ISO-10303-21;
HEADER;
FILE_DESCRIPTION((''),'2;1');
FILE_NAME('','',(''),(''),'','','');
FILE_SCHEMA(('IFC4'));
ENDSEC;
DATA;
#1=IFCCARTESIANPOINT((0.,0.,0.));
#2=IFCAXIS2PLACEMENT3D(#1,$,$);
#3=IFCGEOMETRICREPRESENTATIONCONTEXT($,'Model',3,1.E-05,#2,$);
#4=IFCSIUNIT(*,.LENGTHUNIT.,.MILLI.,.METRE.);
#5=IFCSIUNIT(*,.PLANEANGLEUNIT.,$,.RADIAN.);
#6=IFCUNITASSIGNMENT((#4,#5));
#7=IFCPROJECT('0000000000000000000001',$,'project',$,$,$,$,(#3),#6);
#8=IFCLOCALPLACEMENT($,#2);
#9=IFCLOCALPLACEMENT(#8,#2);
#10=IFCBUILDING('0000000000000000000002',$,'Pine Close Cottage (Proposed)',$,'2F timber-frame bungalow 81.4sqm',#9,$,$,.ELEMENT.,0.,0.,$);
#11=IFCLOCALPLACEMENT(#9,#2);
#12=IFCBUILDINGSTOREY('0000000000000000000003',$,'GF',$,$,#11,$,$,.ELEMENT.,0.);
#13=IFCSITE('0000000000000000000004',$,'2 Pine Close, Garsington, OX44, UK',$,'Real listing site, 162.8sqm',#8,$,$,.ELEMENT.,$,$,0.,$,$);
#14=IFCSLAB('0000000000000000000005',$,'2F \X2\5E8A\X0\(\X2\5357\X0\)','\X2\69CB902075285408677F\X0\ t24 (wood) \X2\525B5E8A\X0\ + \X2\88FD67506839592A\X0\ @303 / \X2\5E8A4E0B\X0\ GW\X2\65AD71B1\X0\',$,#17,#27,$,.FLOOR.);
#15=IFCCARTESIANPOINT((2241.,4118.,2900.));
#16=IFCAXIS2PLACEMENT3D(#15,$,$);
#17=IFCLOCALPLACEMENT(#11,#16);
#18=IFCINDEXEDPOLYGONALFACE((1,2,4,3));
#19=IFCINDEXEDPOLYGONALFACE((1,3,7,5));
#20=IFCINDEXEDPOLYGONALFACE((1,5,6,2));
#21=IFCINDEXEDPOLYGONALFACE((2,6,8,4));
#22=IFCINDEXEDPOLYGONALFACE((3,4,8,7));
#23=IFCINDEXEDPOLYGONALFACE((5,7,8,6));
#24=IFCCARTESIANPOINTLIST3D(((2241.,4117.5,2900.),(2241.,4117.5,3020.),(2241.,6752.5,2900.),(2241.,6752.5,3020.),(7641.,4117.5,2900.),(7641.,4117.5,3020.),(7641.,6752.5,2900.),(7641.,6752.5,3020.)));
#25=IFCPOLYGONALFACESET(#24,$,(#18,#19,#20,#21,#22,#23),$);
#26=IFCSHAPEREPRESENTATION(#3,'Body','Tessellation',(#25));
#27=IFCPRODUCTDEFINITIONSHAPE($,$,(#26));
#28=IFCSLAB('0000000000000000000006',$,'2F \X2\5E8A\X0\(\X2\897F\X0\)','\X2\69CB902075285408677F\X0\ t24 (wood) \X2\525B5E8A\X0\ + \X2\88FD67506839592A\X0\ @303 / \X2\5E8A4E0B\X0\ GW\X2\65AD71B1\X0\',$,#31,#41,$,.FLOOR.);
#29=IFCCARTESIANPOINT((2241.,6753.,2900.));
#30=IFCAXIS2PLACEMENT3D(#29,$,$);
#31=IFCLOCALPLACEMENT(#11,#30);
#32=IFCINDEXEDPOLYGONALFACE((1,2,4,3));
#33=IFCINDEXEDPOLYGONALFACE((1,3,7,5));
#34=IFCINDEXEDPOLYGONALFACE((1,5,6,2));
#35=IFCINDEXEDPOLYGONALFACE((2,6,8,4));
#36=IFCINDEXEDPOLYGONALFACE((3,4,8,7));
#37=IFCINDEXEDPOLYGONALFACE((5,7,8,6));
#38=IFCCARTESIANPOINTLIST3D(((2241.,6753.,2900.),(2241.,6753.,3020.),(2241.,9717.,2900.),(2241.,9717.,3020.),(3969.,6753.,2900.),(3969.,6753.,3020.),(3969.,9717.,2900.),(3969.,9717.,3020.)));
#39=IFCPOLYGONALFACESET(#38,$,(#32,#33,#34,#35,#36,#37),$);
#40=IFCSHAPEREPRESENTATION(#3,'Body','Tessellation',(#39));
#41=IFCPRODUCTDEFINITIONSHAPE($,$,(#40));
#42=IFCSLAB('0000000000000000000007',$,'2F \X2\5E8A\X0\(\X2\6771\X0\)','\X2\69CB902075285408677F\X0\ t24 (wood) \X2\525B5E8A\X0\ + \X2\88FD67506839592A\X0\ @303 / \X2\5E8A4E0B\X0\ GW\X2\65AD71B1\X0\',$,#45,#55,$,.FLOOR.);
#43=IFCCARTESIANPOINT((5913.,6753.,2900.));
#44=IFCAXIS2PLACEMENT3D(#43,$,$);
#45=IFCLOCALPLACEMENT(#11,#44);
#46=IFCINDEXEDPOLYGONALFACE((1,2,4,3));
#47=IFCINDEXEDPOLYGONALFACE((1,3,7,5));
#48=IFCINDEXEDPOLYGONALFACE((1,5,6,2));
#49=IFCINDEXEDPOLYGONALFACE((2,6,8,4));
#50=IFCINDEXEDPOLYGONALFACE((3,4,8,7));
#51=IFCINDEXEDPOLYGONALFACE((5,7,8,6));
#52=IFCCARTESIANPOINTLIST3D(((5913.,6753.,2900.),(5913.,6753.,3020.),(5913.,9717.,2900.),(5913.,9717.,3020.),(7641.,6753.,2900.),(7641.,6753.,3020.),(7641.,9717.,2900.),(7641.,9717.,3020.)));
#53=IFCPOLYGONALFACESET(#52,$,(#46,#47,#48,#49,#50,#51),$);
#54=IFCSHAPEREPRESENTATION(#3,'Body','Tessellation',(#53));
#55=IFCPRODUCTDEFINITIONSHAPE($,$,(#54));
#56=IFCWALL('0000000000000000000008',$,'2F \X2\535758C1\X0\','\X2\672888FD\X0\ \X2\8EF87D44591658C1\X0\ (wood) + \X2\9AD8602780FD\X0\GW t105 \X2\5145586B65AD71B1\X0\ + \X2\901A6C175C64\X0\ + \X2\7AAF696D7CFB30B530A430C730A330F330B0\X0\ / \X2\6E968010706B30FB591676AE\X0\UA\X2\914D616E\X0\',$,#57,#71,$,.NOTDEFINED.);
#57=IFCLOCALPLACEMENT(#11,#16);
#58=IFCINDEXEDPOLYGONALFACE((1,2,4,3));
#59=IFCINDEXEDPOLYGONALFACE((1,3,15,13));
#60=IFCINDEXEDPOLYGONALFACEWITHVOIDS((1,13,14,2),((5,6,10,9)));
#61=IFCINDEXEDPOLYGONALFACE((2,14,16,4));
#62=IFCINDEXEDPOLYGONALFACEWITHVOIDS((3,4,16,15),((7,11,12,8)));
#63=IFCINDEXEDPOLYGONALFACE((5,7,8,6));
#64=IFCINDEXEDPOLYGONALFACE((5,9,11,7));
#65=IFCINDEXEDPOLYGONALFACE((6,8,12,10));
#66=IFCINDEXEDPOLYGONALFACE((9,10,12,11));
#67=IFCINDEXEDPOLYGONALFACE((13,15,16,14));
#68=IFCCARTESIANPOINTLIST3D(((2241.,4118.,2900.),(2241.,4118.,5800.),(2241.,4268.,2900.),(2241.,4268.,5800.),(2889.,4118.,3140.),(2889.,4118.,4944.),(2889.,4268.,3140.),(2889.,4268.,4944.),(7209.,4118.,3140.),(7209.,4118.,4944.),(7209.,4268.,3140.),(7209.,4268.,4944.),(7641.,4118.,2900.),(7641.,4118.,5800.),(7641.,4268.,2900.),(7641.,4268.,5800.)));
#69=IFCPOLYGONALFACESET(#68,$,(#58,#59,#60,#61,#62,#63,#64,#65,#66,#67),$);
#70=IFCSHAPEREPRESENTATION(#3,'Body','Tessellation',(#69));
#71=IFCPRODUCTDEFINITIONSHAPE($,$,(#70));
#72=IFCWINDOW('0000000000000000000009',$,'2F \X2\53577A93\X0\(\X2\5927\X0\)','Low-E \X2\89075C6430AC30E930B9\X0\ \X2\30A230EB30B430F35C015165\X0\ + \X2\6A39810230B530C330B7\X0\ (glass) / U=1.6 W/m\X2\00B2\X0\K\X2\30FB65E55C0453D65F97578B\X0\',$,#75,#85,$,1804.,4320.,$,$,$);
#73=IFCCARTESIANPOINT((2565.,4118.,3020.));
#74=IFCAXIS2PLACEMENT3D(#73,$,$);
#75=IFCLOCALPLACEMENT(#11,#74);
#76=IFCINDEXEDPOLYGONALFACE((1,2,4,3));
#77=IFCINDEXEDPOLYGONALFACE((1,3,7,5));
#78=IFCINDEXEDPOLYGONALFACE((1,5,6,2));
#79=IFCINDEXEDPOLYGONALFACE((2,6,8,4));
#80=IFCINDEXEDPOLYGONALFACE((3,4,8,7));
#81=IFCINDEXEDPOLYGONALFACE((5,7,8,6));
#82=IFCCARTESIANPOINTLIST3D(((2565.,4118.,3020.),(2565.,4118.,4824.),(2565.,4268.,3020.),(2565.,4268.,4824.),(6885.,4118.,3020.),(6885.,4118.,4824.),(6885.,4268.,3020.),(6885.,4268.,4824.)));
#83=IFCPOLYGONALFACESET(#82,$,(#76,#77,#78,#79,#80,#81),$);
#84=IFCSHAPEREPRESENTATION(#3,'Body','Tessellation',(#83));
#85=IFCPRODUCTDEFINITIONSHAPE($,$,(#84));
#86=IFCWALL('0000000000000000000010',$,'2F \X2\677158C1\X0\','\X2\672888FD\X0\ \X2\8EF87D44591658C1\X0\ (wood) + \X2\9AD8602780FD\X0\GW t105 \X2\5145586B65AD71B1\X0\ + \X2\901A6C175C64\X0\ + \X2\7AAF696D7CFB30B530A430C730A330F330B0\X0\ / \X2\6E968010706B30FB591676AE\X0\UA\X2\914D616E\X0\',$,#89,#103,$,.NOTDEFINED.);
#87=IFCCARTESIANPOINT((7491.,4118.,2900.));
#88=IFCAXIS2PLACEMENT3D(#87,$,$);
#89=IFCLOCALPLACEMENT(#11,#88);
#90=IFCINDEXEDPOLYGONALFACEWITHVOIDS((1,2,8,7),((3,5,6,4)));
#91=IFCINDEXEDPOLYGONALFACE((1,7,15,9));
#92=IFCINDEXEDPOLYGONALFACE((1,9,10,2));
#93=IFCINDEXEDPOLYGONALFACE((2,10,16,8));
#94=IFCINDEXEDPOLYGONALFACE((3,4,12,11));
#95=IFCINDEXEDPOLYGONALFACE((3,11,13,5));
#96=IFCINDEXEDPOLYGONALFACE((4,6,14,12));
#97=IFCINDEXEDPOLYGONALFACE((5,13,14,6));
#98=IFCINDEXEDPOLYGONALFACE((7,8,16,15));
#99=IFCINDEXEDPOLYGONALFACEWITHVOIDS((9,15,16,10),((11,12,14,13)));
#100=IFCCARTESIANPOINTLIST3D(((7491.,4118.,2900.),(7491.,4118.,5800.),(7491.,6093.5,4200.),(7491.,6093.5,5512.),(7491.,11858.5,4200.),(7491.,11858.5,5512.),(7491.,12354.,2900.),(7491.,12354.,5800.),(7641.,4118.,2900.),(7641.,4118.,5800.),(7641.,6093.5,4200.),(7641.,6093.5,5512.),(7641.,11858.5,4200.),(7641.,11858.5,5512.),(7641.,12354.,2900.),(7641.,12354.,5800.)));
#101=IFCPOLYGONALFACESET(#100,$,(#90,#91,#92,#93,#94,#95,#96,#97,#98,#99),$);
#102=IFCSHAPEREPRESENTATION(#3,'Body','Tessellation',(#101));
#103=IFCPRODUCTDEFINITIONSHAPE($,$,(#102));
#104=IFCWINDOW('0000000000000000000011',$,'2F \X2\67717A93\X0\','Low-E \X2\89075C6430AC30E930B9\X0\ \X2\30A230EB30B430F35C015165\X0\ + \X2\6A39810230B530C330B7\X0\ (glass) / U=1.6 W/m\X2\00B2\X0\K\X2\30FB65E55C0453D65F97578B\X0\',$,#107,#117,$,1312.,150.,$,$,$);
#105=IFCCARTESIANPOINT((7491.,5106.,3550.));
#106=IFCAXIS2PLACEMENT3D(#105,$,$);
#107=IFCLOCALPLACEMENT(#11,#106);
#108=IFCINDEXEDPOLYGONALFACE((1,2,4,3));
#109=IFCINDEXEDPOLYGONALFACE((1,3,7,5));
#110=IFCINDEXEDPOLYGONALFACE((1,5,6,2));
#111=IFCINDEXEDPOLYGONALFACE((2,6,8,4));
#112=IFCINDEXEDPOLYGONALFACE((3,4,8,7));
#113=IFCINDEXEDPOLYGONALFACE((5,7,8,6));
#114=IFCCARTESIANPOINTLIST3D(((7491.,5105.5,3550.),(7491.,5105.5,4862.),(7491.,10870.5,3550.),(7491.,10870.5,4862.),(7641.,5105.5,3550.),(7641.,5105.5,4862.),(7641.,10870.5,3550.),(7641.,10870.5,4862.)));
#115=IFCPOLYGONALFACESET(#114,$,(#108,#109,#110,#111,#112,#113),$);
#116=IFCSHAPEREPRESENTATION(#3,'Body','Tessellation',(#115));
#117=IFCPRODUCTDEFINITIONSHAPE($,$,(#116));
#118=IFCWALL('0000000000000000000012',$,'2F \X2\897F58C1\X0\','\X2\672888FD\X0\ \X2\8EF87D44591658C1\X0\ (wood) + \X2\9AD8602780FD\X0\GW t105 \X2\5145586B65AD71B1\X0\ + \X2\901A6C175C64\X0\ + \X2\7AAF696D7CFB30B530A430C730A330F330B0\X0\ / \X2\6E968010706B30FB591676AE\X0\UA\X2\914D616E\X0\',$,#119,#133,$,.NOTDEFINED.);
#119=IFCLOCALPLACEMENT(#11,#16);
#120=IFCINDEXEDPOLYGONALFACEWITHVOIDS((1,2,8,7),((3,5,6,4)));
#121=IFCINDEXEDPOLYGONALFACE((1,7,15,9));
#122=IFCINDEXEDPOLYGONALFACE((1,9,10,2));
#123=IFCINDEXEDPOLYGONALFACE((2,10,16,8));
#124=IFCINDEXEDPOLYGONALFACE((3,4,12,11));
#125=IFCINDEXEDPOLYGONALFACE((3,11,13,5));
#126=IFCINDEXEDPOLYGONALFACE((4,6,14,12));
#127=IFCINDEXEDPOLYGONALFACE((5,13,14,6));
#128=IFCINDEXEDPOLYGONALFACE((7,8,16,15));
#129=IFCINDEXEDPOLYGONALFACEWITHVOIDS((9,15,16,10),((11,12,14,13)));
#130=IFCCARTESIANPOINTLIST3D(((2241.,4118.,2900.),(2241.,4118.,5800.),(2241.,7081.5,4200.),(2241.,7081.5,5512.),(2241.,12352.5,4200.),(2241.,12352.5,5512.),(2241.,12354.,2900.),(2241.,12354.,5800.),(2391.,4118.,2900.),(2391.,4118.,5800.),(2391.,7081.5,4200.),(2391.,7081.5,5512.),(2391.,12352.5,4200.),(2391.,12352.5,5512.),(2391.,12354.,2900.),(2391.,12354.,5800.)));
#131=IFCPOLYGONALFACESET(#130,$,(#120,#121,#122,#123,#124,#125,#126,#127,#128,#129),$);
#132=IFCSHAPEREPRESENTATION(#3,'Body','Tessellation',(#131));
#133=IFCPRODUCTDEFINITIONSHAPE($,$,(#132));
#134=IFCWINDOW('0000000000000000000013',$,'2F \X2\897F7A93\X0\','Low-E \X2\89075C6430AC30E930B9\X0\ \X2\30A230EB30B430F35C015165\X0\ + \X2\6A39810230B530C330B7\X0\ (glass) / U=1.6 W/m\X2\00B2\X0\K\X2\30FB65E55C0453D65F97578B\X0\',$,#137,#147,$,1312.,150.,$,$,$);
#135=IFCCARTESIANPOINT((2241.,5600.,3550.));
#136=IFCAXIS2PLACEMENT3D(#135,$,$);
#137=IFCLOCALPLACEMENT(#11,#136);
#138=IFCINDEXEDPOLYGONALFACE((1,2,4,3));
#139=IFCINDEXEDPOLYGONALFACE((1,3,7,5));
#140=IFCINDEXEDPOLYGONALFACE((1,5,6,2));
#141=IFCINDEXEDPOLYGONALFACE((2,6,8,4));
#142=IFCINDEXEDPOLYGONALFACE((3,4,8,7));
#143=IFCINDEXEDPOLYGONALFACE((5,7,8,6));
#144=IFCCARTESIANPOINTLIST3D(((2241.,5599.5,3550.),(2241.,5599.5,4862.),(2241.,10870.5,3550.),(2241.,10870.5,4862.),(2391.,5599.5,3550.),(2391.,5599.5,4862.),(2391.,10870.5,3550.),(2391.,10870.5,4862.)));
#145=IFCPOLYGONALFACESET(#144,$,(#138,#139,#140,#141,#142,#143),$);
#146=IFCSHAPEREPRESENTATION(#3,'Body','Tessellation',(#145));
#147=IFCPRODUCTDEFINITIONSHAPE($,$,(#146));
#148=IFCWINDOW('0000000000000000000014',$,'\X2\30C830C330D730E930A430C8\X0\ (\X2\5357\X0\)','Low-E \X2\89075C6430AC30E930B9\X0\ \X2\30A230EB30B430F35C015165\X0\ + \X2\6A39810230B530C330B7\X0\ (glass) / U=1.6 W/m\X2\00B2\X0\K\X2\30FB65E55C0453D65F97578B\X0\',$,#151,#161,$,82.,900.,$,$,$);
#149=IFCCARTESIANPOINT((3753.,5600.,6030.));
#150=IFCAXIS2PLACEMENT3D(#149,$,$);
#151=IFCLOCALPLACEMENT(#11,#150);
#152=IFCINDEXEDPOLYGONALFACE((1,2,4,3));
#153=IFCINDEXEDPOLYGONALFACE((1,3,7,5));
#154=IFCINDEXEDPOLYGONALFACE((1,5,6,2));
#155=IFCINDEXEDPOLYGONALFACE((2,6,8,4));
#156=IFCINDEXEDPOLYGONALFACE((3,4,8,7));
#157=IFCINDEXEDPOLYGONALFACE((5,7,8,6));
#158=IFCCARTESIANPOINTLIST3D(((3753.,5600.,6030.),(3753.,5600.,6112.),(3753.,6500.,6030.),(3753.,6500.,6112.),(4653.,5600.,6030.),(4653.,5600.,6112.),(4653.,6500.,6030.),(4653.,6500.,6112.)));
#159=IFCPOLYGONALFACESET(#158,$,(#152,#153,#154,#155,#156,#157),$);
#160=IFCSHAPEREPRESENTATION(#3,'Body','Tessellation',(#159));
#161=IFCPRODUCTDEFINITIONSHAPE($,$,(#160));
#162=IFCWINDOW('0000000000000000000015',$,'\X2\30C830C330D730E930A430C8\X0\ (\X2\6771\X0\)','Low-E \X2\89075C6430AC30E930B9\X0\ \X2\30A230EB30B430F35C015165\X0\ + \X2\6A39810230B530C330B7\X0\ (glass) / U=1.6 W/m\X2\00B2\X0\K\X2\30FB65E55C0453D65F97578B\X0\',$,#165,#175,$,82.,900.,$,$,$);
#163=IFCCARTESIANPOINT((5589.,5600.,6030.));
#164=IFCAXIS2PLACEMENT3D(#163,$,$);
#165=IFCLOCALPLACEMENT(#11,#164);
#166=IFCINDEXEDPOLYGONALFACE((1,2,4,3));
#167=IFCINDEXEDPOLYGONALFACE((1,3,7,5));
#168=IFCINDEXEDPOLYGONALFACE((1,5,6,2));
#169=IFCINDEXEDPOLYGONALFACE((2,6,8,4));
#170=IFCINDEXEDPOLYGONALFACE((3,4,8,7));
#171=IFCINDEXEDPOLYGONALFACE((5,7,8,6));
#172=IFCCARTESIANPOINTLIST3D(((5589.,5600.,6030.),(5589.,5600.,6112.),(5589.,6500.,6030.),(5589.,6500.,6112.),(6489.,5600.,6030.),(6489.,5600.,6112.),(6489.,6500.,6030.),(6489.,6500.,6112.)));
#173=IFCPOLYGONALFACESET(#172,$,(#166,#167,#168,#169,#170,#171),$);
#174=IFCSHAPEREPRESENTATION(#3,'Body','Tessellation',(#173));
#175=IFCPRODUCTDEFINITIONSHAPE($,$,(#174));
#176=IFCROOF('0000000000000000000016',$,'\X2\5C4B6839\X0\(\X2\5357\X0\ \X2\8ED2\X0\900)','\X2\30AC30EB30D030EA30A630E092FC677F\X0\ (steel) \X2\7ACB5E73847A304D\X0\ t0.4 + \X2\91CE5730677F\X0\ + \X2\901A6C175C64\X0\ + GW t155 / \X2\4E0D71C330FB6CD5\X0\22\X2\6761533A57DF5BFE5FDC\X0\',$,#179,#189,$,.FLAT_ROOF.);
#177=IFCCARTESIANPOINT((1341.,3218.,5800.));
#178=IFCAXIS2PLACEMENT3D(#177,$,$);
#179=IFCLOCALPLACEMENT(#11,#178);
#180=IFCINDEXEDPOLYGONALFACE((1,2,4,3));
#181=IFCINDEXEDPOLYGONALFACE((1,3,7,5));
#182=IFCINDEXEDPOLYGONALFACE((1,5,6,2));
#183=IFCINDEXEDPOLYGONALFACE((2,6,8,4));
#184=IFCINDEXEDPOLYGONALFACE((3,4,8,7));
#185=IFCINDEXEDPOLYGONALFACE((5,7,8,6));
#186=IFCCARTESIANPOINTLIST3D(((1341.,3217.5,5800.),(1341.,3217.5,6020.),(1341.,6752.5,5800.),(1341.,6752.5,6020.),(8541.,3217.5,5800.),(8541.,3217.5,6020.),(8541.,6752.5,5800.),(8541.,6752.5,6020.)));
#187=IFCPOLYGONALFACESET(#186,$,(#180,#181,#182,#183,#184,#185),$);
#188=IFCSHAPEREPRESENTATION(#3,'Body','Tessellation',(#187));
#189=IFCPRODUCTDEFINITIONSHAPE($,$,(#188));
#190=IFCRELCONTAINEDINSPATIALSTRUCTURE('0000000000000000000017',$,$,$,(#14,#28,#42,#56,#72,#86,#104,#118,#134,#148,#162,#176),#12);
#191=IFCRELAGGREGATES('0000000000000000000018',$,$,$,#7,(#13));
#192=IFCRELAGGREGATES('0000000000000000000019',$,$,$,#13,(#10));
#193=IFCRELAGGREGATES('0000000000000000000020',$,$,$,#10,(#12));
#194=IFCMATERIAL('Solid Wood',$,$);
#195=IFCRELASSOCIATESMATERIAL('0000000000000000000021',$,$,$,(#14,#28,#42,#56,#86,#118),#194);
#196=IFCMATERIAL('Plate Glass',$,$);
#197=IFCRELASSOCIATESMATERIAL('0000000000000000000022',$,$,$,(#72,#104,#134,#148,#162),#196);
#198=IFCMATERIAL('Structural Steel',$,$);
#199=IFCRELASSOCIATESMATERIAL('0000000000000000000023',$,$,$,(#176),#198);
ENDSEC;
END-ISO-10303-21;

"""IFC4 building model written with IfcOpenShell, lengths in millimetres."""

from ifc_helpers import new_model, si_unit, frame, frame_2d, origin, place, context, project, spatial, rectangle, extrude, material, element, fill, save


model = new_model("IFC4")

# Units and contexts
model_context = context("Model", 3, precision=1e-05, world=origin())
ifc_project = project(units=[si_unit("LENGTHUNIT", "METRE", prefix="MILLI"), si_unit("PLANEANGLEUNIT", "RADIAN")], contexts=[model_context])

# Site, building, storey
site_placement = place(None, origin())
site = spatial("IfcSite", under=ifc_project, at=site_placement, Name="2 Pine Close, Garsington, OX44, UK", ObjectType="Real listing site, 162.8sqm", CompositionType="ELEMENT", RefElevation=0.0)
building_placement = place(site_placement, origin())
building = spatial("IfcBuilding", under=site, at=building_placement, Name="Pine Close Cottage (Proposed)", ObjectType="2F timber-frame bungalow 81.4sqm", CompositionType="ELEMENT", ElevationOfRefHeight=0.0, ElevationOfTerrain=0.0)
storey_placement = place(building_placement, origin())
storey = spatial("IfcBuildingStorey", under=building, at=storey_placement, Name="GF", CompositionType="ELEMENT", Elevation=0.0)

# Slabs
ifc_material_1 = material(Name="Solid Wood")
slab_1_placement = place(storey_placement, frame((2241.0, 4118.0, 2900.0)))
element("IfcSlab", 1, at=slab_1_placement, inside=storey, material=ifc_material_1, Name="2F 床(南)", Description="構造用合板 t24 (wood) 剛床 + 製材根太 @303 / 床下 GW断熱", PredefinedType="FLOOR", context=model_context, shape_type="SweptSolid", body=[
    extrude(rectangle(XDim=5400.0, YDim=2635.0, at=frame_2d((2700.0, 1317.0))), frame((2241.0, 4118.0, 2900.0)), (0.0, 0.0, 1.0), 120.0),
])
slab_2_placement = place(storey_placement, frame((2241.0, 6753.0, 2900.0)))
element("IfcSlab", 2, at=slab_2_placement, inside=storey, material=ifc_material_1, Name="2F 床(西)", Description="構造用合板 t24 (wood) 剛床 + 製材根太 @303 / 床下 GW断熱", PredefinedType="FLOOR", context=model_context, shape_type="SweptSolid", body=[
    extrude(rectangle(XDim=1728.0, YDim=2964.0, at=frame_2d((864.0, 1482.0))), frame((2241.0, 6753.0, 2900.0)), (0.0, 0.0, 1.0), 120.0),
])
slab_3_placement = place(storey_placement, frame((5913.0, 6753.0, 2900.0)))
element("IfcSlab", 3, at=slab_3_placement, inside=storey, material=ifc_material_1, Name="2F 床(東)", Description="構造用合板 t24 (wood) 剛床 + 製材根太 @303 / 床下 GW断熱", PredefinedType="FLOOR", context=model_context, shape_type="SweptSolid", body=[
    extrude(rectangle(XDim=1728.0, YDim=2964.0, at=frame_2d((864.0, 1482.0))), frame((5913.0, 6753.0, 2900.0)), (0.0, 0.0, 1.0), 120.0),
])

# Walls, openings, windows
wall_1_placement = place(storey_placement, frame((2241.0, 4118.0, 2900.0)))
wall_1 = element("IfcWall", 4, at=wall_1_placement, inside=storey, material=ifc_material_1, Name="2F 南壁", Description="木製 軸組外壁 (wood) + 高性能GW t105 充填断熱 + 通気層 + 窯業系サイディング / 準耐火・外皮UA配慮", PredefinedType="NOTDEFINED", context=model_context, shape_type="SweptSolid", body=[
    extrude(rectangle(XDim=5400.0, YDim=150.0, at=frame_2d((2700.0, 75.0))), frame((2241.0, 4118.0, 2900.0)), (0.0, 0.0, 1.0), 2900.0),
])
opening_1_placement = place(storey_placement, frame((2565.0, 4118.0, 3020.0)))
opening_1 = element("IfcOpeningElement", 5, at=opening_1_placement, cuts=wall_1, PredefinedType="NOTDEFINED", context=model_context, shape_type="SweptSolid", body=[
    extrude(rectangle(XDim=4320.0, YDim=150.0, at=frame_2d((2160.0, 75.0))), frame((2565.0, 4118.0, 3020.0)), (0.0, 0.0, 1.0), 1804.0),
])
ifc_material_2 = material(Name="Plate Glass")
window_1_placement = place(storey_placement, frame((2565.0, 4118.0, 3020.0)))
window_1 = element("IfcWindow", 6, at=window_1_placement, inside=storey, material=ifc_material_2, Name="2F 南窓(大)", Description="Low-E 複層ガラス アルゴン封入 + 樹脂サッシ (glass) / U=1.6 W/m²K・日射取得型", OverallHeight=1804.0, OverallWidth=4320.0, context=model_context, shape_type="SweptSolid", body=[
    extrude(rectangle(XDim=4320.0, YDim=150.0, at=frame_2d((2160.0, 75.0))), frame((2565.0, 4118.0, 3020.0)), (0.0, 0.0, 1.0), 1804.0),
])
fill(opening_1, window_1)
wall_2_placement = place(storey_placement, frame((7491.0, 4118.0, 2900.0)))
wall_2 = element("IfcWall", 7, at=wall_2_placement, inside=storey, material=ifc_material_1, Name="2F 東壁", Description="木製 軸組外壁 (wood) + 高性能GW t105 充填断熱 + 通気層 + 窯業系サイディング / 準耐火・外皮UA配慮", PredefinedType="NOTDEFINED", context=model_context, shape_type="SweptSolid", body=[
    extrude(rectangle(XDim=150.0, YDim=8236.0, at=frame_2d((75.0, 4118.0))), frame((7491.0, 4118.0, 2900.0)), (0.0, 0.0, 1.0), 2900.0),
])
opening_2_placement = place(storey_placement, frame((7491.0, 5106.0, 3550.0)))
opening_2 = element("IfcOpeningElement", 8, at=opening_2_placement, cuts=wall_2, PredefinedType="NOTDEFINED", context=model_context, shape_type="SweptSolid", body=[
    extrude(rectangle(XDim=150.0, YDim=5765.0, at=frame_2d((75.0, 2882.0))), frame((7491.0, 5106.0, 3550.0)), (0.0, 0.0, 1.0), 1312.0),
])
window_2_placement = place(storey_placement, frame((7491.0, 5106.0, 3550.0)))
window_2 = element("IfcWindow", 9, at=window_2_placement, inside=storey, material=ifc_material_2, Name="2F 東窓", Description="Low-E 複層ガラス アルゴン封入 + 樹脂サッシ (glass) / U=1.6 W/m²K・日射取得型", OverallHeight=1312.0, OverallWidth=150.0, context=model_context, shape_type="SweptSolid", body=[
    extrude(rectangle(XDim=150.0, YDim=5765.0, at=frame_2d((75.0, 2882.0))), frame((7491.0, 5106.0, 3550.0)), (0.0, 0.0, 1.0), 1312.0),
])
fill(opening_2, window_2)
wall_3_placement = place(storey_placement, frame((2241.0, 4118.0, 2900.0)))
wall_3 = element("IfcWall", 10, at=wall_3_placement, inside=storey, material=ifc_material_1, Name="2F 西壁", Description="木製 軸組外壁 (wood) + 高性能GW t105 充填断熱 + 通気層 + 窯業系サイディング / 準耐火・外皮UA配慮", PredefinedType="NOTDEFINED", context=model_context, shape_type="SweptSolid", body=[
    extrude(rectangle(XDim=150.0, YDim=8236.0, at=frame_2d((75.0, 4118.0))), frame((2241.0, 4118.0, 2900.0)), (0.0, 0.0, 1.0), 2900.0),
])
opening_3_placement = place(storey_placement, frame((2241.0, 5600.0, 3550.0)))
opening_3 = element("IfcOpeningElement", 11, at=opening_3_placement, cuts=wall_3, PredefinedType="NOTDEFINED", context=model_context, shape_type="SweptSolid", body=[
    extrude(rectangle(XDim=150.0, YDim=5271.0, at=frame_2d((75.0, 2635.0))), frame((2241.0, 5600.0, 3550.0)), (0.0, 0.0, 1.0), 1312.0),
])
window_3_placement = place(storey_placement, frame((2241.0, 5600.0, 3550.0)))
window_3 = element("IfcWindow", 12, at=window_3_placement, inside=storey, material=ifc_material_2, Name="2F 西窓", Description="Low-E 複層ガラス アルゴン封入 + 樹脂サッシ (glass) / U=1.6 W/m²K・日射取得型", OverallHeight=1312.0, OverallWidth=150.0, context=model_context, shape_type="SweptSolid", body=[
    extrude(rectangle(XDim=150.0, YDim=5271.0, at=frame_2d((75.0, 2635.0))), frame((2241.0, 5600.0, 3550.0)), (0.0, 0.0, 1.0), 1312.0),
])
fill(opening_3, window_3)

# Windows
window_4_placement = place(storey_placement, frame((3753.0, 5600.0, 6030.0)))
element("IfcWindow", 13, at=window_4_placement, inside=storey, material=ifc_material_2, Name="トップライト (南)", Description="Low-E 複層ガラス アルゴン封入 + 樹脂サッシ (glass) / U=1.6 W/m²K・日射取得型", OverallHeight=82.0, OverallWidth=900.0, context=model_context, shape_type="SweptSolid", body=[
    extrude(rectangle(XDim=900.0, YDim=900.0, at=frame_2d((450.0, 450.0))), frame((3753.0, 5600.0, 6030.0)), (0.0, 0.0, 1.0), 82.0),
])
window_5_placement = place(storey_placement, frame((5589.0, 5600.0, 6030.0)))
element("IfcWindow", 14, at=window_5_placement, inside=storey, material=ifc_material_2, Name="トップライト (東)", Description="Low-E 複層ガラス アルゴン封入 + 樹脂サッシ (glass) / U=1.6 W/m²K・日射取得型", OverallHeight=82.0, OverallWidth=900.0, context=model_context, shape_type="SweptSolid", body=[
    extrude(rectangle(XDim=900.0, YDim=900.0, at=frame_2d((450.0, 450.0))), frame((5589.0, 5600.0, 6030.0)), (0.0, 0.0, 1.0), 82.0),
])

# Roof
ifc_material_3 = material(Name="Structural Steel")
roof_1_placement = place(storey_placement, frame((1341.0, 3218.0, 5800.0)))
element("IfcRoof", 15, at=roof_1_placement, inside=storey, material=ifc_material_3, Name="屋根(南 軒900)", Description="ガルバリウム鋼板 (steel) 立平葺き t0.4 + 野地板 + 通気層 + GW t155 / 不燃・法22条区域対応", PredefinedType="FLAT_ROOF", context=model_context, shape_type="SweptSolid", body=[
    extrude(rectangle(XDim=7200.0, YDim=3535.0, at=frame_2d((3600.0, 1767.0))), frame((1341.0, 3218.0, 5800.0)), (0.0, 0.0, 1.0), 220.0),
])

save(model, "model.ifc")
